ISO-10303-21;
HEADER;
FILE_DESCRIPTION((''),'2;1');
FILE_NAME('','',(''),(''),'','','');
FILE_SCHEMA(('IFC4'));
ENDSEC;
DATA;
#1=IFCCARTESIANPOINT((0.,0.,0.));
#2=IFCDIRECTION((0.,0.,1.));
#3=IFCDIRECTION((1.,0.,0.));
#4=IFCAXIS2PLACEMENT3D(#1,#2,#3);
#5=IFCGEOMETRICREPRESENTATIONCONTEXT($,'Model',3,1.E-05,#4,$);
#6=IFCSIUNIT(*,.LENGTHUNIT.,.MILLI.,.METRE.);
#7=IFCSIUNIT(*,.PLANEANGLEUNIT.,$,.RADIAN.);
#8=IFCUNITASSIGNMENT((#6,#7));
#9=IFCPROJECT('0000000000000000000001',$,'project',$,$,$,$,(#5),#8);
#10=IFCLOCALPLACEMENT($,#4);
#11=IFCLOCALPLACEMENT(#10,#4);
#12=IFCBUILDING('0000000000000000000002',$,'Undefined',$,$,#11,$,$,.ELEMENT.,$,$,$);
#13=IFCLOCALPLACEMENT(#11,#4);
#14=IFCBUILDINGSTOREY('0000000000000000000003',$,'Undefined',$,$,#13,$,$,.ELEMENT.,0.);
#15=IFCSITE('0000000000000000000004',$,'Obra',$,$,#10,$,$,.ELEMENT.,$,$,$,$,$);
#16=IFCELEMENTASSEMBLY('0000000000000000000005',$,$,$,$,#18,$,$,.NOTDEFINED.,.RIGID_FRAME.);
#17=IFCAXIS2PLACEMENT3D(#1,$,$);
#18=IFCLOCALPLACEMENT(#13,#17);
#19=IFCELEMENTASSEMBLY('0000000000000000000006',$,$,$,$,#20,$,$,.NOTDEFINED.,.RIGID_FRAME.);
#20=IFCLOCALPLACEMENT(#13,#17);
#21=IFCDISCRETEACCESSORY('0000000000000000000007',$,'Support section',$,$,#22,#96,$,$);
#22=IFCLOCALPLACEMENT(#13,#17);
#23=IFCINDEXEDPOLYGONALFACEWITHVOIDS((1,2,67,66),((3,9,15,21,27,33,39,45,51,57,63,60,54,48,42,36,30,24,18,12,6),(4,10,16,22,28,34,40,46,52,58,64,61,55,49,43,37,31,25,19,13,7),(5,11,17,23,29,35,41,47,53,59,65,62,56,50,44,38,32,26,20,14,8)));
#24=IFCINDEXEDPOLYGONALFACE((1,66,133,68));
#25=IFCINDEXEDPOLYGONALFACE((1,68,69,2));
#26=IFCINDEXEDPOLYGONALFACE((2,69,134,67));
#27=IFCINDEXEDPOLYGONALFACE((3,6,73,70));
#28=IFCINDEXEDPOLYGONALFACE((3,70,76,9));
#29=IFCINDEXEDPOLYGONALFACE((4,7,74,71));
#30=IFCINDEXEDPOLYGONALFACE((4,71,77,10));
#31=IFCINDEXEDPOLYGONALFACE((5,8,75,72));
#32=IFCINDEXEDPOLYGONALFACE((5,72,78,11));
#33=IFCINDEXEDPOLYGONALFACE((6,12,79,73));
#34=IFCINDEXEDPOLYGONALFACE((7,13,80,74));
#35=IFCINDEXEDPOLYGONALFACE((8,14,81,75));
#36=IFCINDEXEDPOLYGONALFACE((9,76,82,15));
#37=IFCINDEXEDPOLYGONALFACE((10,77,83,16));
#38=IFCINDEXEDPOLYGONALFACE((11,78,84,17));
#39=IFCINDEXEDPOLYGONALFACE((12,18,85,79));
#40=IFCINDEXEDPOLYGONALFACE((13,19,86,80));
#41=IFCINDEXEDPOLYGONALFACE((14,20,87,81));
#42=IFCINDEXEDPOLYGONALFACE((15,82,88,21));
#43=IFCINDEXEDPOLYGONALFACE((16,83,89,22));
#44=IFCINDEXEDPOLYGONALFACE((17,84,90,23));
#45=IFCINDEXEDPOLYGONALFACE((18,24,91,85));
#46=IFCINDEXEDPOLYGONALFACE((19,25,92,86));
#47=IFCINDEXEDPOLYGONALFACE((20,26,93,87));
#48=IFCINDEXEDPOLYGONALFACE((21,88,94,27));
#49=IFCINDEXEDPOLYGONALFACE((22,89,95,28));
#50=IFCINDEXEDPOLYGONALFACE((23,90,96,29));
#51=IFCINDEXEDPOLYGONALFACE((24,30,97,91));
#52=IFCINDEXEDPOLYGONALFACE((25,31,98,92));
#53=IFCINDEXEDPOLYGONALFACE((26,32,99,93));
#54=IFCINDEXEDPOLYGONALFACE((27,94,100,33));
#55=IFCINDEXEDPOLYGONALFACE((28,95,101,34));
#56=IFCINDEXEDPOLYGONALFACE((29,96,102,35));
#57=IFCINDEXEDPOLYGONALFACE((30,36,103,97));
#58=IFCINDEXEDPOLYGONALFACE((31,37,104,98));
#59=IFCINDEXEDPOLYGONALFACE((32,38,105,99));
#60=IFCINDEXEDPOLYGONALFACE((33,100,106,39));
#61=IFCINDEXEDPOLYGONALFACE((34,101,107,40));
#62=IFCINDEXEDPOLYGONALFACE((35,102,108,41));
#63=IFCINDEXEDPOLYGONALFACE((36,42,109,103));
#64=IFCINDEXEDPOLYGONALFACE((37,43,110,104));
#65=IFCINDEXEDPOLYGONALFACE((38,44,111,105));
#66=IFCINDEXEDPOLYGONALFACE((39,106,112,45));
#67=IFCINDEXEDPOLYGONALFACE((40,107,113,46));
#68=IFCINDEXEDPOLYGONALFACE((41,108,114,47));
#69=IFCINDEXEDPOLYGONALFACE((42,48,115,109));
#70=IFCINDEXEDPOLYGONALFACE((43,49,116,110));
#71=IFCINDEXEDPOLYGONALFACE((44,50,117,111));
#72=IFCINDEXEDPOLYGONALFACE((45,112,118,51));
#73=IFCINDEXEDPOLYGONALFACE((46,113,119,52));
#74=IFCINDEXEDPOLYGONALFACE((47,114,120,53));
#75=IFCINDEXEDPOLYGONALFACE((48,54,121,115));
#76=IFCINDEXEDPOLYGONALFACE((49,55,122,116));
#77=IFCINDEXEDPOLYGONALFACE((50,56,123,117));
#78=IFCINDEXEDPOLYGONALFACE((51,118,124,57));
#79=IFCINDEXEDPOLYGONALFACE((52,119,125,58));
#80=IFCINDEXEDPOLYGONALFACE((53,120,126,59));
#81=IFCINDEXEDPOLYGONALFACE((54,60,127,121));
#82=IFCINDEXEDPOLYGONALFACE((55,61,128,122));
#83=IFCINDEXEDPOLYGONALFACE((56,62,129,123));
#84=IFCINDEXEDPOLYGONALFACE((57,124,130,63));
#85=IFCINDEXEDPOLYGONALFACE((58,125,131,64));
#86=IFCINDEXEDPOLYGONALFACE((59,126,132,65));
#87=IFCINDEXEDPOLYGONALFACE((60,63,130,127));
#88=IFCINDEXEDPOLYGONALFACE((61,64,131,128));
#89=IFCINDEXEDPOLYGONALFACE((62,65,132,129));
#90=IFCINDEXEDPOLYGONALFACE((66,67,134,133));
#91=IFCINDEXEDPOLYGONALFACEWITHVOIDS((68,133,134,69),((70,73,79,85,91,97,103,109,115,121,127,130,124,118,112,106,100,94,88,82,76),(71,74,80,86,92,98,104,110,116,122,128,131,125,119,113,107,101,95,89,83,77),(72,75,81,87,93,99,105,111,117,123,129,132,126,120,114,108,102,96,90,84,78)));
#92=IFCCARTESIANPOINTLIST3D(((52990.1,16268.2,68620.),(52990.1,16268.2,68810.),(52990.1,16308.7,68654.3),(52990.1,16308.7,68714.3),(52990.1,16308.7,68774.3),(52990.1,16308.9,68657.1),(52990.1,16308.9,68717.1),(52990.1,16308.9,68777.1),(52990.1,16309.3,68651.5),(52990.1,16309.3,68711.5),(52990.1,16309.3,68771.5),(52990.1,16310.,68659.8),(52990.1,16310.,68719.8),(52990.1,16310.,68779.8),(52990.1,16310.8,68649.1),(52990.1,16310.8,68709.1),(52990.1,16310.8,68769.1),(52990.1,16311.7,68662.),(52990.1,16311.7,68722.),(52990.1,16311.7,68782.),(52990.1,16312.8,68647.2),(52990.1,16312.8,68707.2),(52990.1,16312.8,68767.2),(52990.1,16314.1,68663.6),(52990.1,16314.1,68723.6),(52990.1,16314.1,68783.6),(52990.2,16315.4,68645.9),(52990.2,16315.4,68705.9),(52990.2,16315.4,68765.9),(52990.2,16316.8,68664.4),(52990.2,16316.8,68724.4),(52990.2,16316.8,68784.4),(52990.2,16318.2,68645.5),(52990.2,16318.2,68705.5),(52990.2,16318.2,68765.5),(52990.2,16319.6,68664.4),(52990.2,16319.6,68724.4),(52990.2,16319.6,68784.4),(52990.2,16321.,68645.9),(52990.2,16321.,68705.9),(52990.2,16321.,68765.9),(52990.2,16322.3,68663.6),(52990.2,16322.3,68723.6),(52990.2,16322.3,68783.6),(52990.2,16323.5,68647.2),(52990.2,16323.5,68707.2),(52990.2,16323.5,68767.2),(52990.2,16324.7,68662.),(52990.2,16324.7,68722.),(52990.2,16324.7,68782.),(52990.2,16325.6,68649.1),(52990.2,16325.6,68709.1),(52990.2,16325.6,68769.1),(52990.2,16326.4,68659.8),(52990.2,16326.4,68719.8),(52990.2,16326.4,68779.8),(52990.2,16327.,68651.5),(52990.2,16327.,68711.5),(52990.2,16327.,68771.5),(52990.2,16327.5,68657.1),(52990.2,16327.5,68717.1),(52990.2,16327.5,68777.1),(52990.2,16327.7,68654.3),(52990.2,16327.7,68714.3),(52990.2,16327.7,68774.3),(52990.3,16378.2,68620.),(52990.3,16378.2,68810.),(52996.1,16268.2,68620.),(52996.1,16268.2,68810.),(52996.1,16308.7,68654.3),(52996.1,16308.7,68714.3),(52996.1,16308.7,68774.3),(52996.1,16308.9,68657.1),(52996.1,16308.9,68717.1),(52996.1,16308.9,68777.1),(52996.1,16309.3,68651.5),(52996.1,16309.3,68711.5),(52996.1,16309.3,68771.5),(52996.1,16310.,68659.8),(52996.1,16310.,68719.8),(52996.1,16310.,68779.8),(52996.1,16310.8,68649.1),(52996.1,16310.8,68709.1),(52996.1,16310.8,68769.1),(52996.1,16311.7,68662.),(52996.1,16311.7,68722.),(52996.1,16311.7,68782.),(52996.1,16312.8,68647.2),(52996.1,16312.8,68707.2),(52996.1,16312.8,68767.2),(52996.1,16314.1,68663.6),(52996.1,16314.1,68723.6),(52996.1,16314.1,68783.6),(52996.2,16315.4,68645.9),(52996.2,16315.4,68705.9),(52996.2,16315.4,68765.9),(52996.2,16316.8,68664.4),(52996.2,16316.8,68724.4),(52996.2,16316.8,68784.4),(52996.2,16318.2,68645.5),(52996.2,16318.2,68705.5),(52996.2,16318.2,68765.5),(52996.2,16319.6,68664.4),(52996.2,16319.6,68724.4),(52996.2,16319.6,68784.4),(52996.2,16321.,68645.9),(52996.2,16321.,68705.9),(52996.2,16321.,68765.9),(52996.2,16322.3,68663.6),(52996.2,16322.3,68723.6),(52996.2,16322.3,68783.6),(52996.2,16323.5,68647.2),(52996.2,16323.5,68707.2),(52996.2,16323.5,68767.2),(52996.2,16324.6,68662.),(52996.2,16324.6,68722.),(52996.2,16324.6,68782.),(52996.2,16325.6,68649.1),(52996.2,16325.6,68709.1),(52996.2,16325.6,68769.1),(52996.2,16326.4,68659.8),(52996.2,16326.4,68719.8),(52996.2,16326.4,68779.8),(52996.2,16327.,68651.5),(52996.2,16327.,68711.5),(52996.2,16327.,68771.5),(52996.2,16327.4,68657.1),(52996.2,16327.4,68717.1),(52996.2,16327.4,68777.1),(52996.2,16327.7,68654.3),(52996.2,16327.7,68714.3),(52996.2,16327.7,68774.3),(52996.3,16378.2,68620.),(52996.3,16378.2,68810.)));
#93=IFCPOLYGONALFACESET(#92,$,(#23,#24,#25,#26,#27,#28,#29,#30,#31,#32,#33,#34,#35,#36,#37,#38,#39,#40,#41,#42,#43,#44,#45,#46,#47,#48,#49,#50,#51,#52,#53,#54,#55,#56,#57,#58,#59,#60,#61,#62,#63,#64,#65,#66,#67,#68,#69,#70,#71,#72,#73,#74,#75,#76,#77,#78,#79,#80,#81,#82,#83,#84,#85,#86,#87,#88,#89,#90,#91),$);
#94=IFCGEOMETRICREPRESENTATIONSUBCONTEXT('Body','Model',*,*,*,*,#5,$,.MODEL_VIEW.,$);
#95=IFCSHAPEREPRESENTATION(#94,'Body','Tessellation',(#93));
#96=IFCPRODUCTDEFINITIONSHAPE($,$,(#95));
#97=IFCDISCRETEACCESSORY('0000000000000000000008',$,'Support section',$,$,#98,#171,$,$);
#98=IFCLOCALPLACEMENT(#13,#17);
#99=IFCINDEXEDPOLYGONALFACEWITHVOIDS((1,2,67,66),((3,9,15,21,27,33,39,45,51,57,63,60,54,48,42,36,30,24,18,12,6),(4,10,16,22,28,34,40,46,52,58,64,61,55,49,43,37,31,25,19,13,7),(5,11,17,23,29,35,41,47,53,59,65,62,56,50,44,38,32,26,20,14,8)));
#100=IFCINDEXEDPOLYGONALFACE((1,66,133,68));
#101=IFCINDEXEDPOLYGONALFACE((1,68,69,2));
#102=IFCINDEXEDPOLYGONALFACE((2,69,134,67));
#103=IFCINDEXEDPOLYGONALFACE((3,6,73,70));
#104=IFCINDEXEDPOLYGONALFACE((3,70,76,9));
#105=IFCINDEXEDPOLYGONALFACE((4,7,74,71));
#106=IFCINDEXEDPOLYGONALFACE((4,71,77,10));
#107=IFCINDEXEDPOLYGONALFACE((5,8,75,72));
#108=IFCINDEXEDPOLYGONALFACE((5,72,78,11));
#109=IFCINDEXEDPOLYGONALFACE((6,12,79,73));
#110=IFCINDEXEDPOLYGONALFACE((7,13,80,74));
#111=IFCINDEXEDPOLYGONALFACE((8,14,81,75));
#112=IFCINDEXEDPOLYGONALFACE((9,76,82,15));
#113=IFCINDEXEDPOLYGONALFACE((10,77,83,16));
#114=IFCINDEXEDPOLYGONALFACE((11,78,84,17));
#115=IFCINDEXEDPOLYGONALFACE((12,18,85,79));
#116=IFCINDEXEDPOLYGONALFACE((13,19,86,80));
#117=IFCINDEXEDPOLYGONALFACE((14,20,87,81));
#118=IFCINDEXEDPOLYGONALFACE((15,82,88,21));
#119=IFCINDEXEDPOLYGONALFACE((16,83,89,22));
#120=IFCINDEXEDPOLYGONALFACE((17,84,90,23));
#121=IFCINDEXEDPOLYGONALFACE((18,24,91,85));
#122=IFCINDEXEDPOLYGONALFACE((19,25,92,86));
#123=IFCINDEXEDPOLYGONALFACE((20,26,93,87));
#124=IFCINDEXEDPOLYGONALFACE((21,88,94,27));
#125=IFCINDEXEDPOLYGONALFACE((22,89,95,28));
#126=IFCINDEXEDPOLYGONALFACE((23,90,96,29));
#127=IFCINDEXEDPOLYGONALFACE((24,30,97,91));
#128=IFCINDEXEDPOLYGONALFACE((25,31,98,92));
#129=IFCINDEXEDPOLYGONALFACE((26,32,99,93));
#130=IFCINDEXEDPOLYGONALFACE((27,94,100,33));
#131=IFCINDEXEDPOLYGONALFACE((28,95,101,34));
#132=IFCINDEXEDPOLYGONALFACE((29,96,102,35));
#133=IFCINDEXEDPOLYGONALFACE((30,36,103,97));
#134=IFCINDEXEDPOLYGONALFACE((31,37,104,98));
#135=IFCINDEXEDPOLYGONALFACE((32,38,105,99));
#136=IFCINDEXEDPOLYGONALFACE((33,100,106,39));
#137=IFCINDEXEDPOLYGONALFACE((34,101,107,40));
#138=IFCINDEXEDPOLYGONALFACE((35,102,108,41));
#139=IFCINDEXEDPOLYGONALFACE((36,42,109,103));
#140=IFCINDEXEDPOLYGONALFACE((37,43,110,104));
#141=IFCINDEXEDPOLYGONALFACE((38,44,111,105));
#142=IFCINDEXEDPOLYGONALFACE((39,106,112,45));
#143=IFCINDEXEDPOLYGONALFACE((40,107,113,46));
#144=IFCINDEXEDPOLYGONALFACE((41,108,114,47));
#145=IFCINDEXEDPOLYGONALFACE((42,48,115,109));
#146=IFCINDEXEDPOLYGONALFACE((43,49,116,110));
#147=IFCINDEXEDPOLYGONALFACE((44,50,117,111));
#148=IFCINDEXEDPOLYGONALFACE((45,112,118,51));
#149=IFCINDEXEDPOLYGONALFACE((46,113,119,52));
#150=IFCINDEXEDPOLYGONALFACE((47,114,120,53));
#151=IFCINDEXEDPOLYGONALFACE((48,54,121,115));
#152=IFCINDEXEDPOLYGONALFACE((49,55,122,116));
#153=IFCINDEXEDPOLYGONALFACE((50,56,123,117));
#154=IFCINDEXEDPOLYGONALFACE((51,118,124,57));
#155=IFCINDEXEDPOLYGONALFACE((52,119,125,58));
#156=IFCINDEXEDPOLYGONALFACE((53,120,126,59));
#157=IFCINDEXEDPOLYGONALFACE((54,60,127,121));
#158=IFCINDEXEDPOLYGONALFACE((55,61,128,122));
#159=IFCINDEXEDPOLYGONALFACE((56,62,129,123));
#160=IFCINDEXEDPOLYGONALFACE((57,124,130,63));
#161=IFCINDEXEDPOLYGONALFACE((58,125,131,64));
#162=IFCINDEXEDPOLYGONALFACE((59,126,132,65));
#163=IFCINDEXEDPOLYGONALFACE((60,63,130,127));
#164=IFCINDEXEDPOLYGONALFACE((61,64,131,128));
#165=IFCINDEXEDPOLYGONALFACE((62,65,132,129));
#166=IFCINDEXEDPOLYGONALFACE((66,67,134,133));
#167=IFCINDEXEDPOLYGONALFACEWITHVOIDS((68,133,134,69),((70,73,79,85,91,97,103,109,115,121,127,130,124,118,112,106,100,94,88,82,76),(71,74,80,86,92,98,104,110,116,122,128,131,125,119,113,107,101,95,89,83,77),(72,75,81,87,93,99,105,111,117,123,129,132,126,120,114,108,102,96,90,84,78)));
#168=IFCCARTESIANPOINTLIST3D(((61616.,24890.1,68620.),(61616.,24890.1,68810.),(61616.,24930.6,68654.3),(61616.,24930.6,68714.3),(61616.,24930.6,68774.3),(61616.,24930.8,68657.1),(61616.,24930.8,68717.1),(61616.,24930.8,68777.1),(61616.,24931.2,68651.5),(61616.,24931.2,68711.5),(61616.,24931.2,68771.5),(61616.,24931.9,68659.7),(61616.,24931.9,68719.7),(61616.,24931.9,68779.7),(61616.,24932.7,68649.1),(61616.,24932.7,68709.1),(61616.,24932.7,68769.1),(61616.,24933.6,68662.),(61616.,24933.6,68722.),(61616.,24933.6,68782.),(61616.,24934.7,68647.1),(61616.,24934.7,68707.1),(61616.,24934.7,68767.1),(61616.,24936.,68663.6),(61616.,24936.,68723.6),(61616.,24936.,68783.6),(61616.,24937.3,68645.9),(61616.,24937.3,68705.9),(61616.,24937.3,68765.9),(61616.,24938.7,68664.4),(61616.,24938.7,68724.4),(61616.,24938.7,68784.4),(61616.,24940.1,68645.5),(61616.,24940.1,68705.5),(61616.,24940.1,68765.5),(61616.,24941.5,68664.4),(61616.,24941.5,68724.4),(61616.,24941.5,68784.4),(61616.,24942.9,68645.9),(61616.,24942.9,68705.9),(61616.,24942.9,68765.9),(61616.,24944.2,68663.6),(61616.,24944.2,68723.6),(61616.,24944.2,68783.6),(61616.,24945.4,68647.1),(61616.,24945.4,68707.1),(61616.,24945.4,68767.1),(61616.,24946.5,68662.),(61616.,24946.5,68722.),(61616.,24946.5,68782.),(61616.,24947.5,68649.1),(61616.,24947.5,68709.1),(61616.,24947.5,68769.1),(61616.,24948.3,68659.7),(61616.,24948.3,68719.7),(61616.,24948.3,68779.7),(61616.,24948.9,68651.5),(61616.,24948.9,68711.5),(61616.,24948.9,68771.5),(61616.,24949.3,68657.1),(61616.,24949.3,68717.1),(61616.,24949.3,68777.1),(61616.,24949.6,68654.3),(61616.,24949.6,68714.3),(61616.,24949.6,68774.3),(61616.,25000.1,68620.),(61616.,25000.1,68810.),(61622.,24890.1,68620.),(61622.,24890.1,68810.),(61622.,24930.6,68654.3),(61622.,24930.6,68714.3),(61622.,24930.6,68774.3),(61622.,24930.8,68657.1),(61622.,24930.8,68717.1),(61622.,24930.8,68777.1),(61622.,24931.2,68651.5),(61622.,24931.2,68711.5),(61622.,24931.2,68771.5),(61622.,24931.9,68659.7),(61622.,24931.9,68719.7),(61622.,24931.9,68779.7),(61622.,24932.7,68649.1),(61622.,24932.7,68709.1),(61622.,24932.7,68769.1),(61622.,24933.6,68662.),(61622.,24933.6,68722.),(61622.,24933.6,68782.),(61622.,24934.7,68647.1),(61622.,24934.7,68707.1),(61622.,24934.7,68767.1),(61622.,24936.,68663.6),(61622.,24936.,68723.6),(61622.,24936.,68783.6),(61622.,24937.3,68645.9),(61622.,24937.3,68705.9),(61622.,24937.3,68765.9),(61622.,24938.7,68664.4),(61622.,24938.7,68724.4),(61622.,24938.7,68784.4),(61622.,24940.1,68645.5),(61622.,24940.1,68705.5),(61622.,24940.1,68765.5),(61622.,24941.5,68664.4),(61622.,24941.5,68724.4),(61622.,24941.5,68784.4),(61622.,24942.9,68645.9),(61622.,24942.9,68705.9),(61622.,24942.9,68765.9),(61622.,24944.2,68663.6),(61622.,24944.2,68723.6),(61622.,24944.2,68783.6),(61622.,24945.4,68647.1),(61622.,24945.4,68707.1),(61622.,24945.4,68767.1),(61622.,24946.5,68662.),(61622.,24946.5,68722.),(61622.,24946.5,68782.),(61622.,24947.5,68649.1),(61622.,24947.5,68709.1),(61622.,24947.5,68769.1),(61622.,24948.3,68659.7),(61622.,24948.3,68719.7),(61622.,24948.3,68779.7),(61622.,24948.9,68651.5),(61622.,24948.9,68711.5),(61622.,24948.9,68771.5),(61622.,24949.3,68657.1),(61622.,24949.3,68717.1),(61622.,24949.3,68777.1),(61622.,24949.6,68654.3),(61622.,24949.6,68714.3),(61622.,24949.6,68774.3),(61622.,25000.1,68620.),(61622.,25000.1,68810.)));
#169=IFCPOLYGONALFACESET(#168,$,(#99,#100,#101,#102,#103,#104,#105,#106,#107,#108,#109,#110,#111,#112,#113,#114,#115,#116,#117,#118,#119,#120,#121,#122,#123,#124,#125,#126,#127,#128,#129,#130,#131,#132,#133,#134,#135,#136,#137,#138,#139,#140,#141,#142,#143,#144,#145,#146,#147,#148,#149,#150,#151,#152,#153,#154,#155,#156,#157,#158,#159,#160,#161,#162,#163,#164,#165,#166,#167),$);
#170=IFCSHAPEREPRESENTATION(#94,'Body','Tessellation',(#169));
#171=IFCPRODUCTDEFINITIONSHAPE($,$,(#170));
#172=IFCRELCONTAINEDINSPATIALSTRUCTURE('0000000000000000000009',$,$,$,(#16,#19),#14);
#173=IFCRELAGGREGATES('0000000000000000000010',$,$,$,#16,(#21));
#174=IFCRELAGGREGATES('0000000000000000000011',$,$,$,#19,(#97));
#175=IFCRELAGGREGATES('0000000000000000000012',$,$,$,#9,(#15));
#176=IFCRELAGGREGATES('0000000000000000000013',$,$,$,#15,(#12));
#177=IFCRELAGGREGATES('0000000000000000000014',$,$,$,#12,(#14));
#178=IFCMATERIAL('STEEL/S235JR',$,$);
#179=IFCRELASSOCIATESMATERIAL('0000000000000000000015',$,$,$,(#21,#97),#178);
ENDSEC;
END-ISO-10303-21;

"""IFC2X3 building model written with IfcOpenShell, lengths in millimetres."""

from ifc_helpers import new_model, si_unit, frame, origin_with_axes, origin_2d_with_axis, place, context, subcontext, project, spatial, rectangle, circle, extrude, source, transform, mapped, material, element, aggregate, save


model = new_model("IFC2X3")

# Units and contexts
model_context = context("Model", 3, precision=1e-05, world=origin_with_axes())
body_context = subcontext(model_context, "Body", "Model", "MODEL_VIEW")
ifc_project = project(units=[si_unit("LENGTHUNIT", "METRE", prefix="MILLI"), si_unit("PLANEANGLEUNIT", "RADIAN")], contexts=[model_context])

# Site, building, storey
site_placement = place(None, origin_with_axes())
site = spatial("IfcSite", under=ifc_project, at=site_placement, Name="Obra", CompositionType="ELEMENT")
building_placement = place(site_placement, origin_with_axes())
building = spatial("IfcBuilding", under=site, at=building_placement, Name="Undefined", CompositionType="ELEMENT")
storey_placement = place(building_placement, origin_with_axes())
storey = spatial("IfcBuildingStorey", under=building, at=storey_placement, Name="Undefined", CompositionType="ELEMENT", Elevation=0.0)

# Element assemblies
ifc_material_1 = material(Name="STEEL/S235JR")
assembly_1_placement = place(storey_placement, origin_with_axes())
assembly_1 = element("IfcElementAssembly", 1, at=assembly_1_placement, inside=storey, AssemblyPlace="NOTDEFINED", PredefinedType="RIGID_FRAME")
assembly_2_placement = place(storey_placement, origin_with_axes())
assembly_2 = element("IfcElementAssembly", 2, at=assembly_2_placement, inside=storey, AssemblyPlace="NOTDEFINED", PredefinedType="RIGID_FRAME")

# Discrete accessories, openings
shared_shape_1 = source(origin_with_axes(), body_context, "Body", "SweptSolid", [
    extrude(circle(Radius=9.5, at=origin_2d_with_axis()), frame((0.0, -9.2, 0.0), z_axis=(0.0, 1.0, 0.0), x_axis=(1.0, 0.0, 0.0)), (0.0, 0.0, 1.0), 6.2),
])
discrete_accessory_1_placement = place(assembly_1_placement, frame((52993.2, 16323.2, 68620.0), z_axis=(0.0, 0.0, 1.0), x_axis=(0.001649, 0.999999, 0.0)))
discrete_accessory_1 = element("IfcDiscreteAccessory", 3, at=discrete_accessory_1_placement, material=ifc_material_1, Name="Support section", context=body_context, shape_type="SweptSolid", body=[
    extrude(rectangle(XDim=6.0, YDim=110.0, at=origin_2d_with_axis()), frame((0.0, 0.0, 190.0), z_axis=(0.0, 0.0, -1.0), x_axis=(0.0, 1.0, 0.0)), (0.0, 0.0, 1.0), 190.0),
])
opening_1_placement = place(assembly_1_placement, frame((52999.3, 16368.2, 68835.0), z_axis=(-0.001649, -0.999999, 0.0), x_axis=(0.0, 0.0, -1.0)))
element("IfcOpeningElement", 4, at=opening_1_placement, cuts=discrete_accessory_1, ObjectType="Opening", context=body_context, shape_type="MappedRepresentation", body=[
    mapped(shared_shape_1, transform((60.0, 0.0, 50.0))),
    mapped(shared_shape_1, transform((120.0, 0.0, 50.0))),
    mapped(shared_shape_1, transform((180.0, 0.0, 50.0))),
])
aggregate(assembly_1, [discrete_accessory_1])
discrete_accessory_2_placement = place(assembly_2_placement, frame((61619.0, 24945.1, 68620.0), z_axis=(0.0, 0.0, 1.0), x_axis=(-0.000002, 1.0, 0.0)))
discrete_accessory_2 = element("IfcDiscreteAccessory", 5, at=discrete_accessory_2_placement, material=ifc_material_1, Name="Support section", context=body_context, shape_type="SweptSolid", body=[
    extrude(rectangle(XDim=6.0, YDim=110.0, at=origin_2d_with_axis()), frame((0.0, 0.0, 190.0), z_axis=(0.0, 0.0, -1.0), x_axis=(0.0, 1.0, 0.0)), (0.0, 0.0, 1.0), 190.0),
])
opening_2_placement = place(assembly_2_placement, frame((61625.1, 24990.1, 68835.0), z_axis=(0.000002, -1.0, 0.0), x_axis=(0.0, 0.0, -1.0)))
element("IfcOpeningElement", 6, at=opening_2_placement, cuts=discrete_accessory_2, ObjectType="Opening", context=body_context, shape_type="MappedRepresentation", body=[
    mapped(shared_shape_1, transform((60.0, 0.0, 50.0))),
    mapped(shared_shape_1, transform((120.0, 0.0, 50.0))),
    mapped(shared_shape_1, transform((180.0, 0.0, 50.0))),
])
aggregate(assembly_2, [discrete_accessory_2])

save(model, "model.ifc")
